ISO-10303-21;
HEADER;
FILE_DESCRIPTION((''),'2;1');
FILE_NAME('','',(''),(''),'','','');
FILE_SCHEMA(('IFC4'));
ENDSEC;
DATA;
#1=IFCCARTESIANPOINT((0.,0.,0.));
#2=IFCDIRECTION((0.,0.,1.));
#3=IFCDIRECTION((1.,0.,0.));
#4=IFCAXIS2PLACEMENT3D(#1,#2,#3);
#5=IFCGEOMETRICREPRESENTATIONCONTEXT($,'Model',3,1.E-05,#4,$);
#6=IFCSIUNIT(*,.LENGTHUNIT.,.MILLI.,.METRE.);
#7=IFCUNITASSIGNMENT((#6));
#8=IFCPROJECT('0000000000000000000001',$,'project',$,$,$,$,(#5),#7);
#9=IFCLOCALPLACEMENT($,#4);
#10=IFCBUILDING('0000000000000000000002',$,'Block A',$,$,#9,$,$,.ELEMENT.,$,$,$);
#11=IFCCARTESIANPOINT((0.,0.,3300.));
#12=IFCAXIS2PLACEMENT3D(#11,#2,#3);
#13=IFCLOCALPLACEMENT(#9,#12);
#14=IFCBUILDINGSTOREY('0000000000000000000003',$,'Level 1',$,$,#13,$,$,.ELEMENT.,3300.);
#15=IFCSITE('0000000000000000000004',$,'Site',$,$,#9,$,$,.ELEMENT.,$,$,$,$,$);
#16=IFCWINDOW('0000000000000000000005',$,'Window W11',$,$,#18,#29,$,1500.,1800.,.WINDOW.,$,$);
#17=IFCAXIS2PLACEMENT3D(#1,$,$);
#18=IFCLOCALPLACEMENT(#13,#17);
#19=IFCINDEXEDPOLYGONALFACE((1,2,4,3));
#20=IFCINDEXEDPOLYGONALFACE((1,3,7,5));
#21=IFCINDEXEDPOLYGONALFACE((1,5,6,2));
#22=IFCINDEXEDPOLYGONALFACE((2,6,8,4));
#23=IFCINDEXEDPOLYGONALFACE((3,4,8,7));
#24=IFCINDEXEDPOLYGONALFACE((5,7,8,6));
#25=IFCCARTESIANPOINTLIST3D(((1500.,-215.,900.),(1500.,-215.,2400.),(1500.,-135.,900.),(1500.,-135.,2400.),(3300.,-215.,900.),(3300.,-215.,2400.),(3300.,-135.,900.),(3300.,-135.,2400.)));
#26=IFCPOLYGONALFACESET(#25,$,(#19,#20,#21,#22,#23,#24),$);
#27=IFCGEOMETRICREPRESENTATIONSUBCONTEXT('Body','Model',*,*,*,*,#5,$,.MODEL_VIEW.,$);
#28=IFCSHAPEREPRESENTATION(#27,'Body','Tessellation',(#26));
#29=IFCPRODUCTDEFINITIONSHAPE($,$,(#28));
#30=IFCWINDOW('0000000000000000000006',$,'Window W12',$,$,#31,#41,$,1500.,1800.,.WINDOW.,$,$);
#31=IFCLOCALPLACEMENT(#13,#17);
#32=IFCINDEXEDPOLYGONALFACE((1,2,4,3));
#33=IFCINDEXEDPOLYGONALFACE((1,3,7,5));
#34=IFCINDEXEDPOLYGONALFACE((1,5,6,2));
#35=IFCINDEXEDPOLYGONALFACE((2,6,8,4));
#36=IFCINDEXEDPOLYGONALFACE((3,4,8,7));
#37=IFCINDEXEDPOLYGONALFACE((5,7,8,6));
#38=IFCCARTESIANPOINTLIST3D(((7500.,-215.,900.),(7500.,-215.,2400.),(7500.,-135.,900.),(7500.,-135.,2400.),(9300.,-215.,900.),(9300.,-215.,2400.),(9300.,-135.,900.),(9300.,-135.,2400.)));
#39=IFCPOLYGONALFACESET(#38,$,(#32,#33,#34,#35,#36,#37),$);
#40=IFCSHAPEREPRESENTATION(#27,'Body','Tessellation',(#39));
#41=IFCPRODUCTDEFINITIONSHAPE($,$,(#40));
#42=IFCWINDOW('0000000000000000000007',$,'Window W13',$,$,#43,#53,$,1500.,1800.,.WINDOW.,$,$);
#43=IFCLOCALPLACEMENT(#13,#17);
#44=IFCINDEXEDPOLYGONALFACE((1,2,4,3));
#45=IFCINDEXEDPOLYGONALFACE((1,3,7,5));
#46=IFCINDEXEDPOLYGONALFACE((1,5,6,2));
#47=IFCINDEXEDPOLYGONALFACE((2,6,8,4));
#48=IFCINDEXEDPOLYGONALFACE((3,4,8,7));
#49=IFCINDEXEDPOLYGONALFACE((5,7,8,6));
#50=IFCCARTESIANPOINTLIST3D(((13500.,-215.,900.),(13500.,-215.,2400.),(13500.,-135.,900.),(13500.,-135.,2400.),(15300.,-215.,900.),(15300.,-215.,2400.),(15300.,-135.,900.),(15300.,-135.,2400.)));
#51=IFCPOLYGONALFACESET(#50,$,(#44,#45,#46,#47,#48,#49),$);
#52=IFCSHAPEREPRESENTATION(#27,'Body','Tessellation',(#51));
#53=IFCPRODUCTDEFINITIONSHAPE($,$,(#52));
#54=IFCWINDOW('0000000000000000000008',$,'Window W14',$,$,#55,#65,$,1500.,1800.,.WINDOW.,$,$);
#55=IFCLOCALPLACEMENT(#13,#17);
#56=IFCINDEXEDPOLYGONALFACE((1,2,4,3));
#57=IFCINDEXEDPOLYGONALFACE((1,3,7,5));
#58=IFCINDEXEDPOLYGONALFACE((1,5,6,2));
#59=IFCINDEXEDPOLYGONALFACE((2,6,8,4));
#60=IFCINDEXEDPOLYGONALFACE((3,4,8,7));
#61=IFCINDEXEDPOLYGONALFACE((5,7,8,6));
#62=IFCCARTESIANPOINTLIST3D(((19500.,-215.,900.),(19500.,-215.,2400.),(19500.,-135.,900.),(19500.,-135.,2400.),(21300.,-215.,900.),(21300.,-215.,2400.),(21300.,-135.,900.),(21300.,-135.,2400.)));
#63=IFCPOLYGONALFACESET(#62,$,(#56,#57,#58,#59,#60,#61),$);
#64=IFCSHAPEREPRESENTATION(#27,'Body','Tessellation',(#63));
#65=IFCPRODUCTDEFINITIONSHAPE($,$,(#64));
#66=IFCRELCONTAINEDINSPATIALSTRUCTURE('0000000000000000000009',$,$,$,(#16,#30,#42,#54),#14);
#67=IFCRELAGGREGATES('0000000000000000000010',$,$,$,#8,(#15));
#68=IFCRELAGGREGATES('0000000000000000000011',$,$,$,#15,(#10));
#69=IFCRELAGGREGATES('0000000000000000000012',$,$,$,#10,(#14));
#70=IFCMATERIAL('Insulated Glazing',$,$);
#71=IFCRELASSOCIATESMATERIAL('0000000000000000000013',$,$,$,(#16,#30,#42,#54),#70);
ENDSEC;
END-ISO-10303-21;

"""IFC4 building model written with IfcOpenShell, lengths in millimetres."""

from ifc_helpers import new_model, si_unit, frame, frame_2d, origin_with_axes, place, context, subcontext, project, spatial, rectangle, extrude, material, element, save


model = new_model("IFC4")

# Units and contexts
model_context = context("Model", 3, precision=1e-05, world=origin_with_axes())
body_context = subcontext(model_context, "Body", "Model", "MODEL_VIEW")
ifc_project = project(units=[si_unit("LENGTHUNIT", "METRE", prefix="MILLI")], contexts=[model_context])

# Site, building, storey
placement = place(None, origin_with_axes())
site = spatial("IfcSite", under=ifc_project, at=placement, Name="Site", CompositionType="ELEMENT")
building = spatial("IfcBuilding", under=site, at=placement, Name="Block A", CompositionType="ELEMENT")
storey_placement = place(placement, frame((0.0, 0.0, 3300.0), z_axis=(0.0, 0.0, 1.0), x_axis=(1.0, 0.0, 0.0)))
storey = spatial("IfcBuildingStorey", under=building, at=storey_placement, Name="Level 1", CompositionType="ELEMENT", Elevation=3300.0)

# Windows
ifc_material_1 = material(Name="Insulated Glazing")
for number, where, z_axis, x_axis, name in (
    (1, (1500.0, -215.0, 4200.0), (0.0, 0.0, 1.0), (1.0, 0.0, 0.0), "Window W11"),
    (2, (7500.0, -215.0, 4200.0), (0.0, 0.0, 1.0), (1.0, 0.0, 0.0), "Window W12"),
    (3, (13500.0, -215.0, 4200.0), (0.0, 0.0, 1.0), (1.0, 0.0, 0.0), "Window W13"),
    (4, (19500.0, -215.0, 4200.0), (0.0, 0.0, 1.0), (1.0, 0.0, 0.0), "Window W14"),
):
    element("IfcWindow", number, at=place(placement, frame(where, z_axis=z_axis, x_axis=x_axis)), inside=storey, material=ifc_material_1, Name=name, OverallHeight=1500.0, OverallWidth=1800.0, PredefinedType="WINDOW", context=body_context, shape_type="SweptSolid", body=[
        extrude(rectangle(XDim=1800.0, YDim=80.0, at=frame_2d((900.0, 40.0))), origin_with_axes(), (0.0, 0.0, 1.0), 1500.0),
    ])

save(model, "model.ifc")
